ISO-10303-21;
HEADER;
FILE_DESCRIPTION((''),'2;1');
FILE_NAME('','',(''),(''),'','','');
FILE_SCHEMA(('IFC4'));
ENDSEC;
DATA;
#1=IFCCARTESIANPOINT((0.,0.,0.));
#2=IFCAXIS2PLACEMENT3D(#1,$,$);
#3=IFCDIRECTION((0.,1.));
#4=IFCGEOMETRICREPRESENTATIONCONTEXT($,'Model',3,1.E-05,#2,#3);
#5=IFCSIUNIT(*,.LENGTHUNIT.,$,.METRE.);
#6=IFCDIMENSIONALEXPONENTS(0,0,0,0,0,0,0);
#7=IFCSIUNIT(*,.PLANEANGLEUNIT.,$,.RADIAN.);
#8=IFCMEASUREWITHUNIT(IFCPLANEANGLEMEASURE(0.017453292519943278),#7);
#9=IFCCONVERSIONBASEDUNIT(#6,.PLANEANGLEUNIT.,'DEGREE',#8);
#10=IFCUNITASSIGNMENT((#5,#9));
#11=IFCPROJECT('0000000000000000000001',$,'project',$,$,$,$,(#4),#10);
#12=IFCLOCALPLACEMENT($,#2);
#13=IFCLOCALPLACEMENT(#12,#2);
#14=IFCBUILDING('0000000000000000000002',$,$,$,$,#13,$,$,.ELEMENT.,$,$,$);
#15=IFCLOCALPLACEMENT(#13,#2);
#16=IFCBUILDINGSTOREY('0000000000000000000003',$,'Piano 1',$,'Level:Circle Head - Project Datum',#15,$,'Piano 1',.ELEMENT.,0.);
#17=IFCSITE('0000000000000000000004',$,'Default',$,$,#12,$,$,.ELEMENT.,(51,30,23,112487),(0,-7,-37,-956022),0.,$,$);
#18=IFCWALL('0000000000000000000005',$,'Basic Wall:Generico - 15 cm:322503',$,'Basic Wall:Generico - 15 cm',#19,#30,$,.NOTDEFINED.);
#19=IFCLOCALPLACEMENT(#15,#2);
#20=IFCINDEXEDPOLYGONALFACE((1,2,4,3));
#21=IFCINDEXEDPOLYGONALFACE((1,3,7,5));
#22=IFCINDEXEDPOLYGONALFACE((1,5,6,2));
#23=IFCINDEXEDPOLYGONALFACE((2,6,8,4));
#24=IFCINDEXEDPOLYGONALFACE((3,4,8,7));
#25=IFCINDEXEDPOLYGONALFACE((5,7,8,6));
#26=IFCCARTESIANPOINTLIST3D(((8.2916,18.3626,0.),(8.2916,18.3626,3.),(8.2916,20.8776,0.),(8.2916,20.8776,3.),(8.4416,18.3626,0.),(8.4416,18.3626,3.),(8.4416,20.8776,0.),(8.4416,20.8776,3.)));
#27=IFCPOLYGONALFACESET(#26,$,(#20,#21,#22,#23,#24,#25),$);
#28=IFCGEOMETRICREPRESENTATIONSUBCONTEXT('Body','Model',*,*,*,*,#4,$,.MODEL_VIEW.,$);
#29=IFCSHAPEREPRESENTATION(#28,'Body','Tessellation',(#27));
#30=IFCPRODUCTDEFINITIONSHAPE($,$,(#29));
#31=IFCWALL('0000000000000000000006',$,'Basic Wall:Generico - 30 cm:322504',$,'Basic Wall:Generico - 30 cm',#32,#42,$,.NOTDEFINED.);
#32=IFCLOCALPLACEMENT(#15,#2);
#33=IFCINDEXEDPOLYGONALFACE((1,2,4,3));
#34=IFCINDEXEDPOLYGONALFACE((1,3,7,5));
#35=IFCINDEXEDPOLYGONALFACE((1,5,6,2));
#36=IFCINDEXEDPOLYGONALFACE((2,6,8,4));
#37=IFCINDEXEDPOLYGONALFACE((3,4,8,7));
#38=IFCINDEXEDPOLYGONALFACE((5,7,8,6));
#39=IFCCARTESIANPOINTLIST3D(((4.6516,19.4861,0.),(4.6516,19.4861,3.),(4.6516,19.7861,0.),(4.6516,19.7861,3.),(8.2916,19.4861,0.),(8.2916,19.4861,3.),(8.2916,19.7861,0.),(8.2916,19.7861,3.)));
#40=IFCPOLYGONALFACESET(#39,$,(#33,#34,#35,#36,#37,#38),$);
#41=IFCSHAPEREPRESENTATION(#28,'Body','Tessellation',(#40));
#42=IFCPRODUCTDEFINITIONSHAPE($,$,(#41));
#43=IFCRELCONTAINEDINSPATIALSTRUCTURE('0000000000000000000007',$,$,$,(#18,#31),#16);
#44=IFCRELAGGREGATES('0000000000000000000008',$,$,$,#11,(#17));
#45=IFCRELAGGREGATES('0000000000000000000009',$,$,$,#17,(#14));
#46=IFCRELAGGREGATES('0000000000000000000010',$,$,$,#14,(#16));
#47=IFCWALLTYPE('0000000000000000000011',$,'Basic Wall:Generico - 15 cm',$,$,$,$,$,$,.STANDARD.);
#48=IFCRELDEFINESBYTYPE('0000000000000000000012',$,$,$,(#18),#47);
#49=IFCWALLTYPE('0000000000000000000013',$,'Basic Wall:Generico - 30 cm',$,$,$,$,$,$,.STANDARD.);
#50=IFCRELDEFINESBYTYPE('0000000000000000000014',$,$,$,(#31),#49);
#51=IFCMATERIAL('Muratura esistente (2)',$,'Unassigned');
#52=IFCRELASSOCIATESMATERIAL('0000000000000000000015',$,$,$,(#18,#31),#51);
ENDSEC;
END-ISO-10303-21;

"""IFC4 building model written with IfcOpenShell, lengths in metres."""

from ifc_helpers import new_model, entity, si_unit, converted_unit, direction, frame, origin, place, context, subcontext, project, spatial, indexed_curve, outline, extrude, material, type_object, element, save


model = new_model("IFC4")

# Units and contexts
model_context = context("Model", 3, precision=1e-05, world=origin(), true_north=direction((0.0, 1.0)))
body_context = subcontext(model_context, "Body", "Model", "MODEL_VIEW")
ifc_project = project(units=[si_unit("LENGTHUNIT", "METRE"), converted_unit("PLANEANGLEUNIT", "DEGREE", entity("IfcPlaneAngleMeasure", 0.017453292519943278), si_unit("PLANEANGLEUNIT", "RADIAN"), dimensions=[0, 0, 0, 0, 0, 0, 0])], contexts=[model_context])

# Site, building, storey
site_placement = place(None, origin())
site = spatial("IfcSite", under=ifc_project, at=site_placement, Name="Default", CompositionType="ELEMENT", RefLatitude=(51, 30, 23, 112487), RefLongitude=(0, -7, -37, -956022), RefElevation=0.0)
building_placement = place(site_placement, origin())
building = spatial("IfcBuilding", under=site, at=building_placement, CompositionType="ELEMENT")
storey_placement = place(building_placement, origin())
storey = spatial("IfcBuildingStorey", under=building, at=storey_placement, Name="Piano 1", ObjectType="Level:Circle Head - Project Datum", LongName="Piano 1", CompositionType="ELEMENT", Elevation=0.0)

# Walls
ifc_material = material(Name="Muratura esistente (2)", Category="Unassigned")
wall_type_1 = type_object("IfcWallType", Name="Basic Wall:Generico - 15 cm", PredefinedType="STANDARD")
wall_1_placement = place(storey_placement, frame((8.3666, 20.8776, 0.0), z_axis=(0.0, 0.0, 1.0), x_axis=(0.0, -1.0, 0.0)))
element("IfcWall", 1, at=wall_1_placement, inside=storey, type_object=wall_type_1, material=ifc_material, Name="Basic Wall:Generico - 15 cm:322503", ObjectType="Basic Wall:Generico - 15 cm", PredefinedType="NOTDEFINED", context=body_context, shape_type="SweptSolid", body=[
    extrude(outline(indexed_curve([(2.515, 0.075), (0.0, 0.075), (0.0, -0.075), (2.515, -0.075), (2.515, 0.075)], self_intersect=False)), origin(), (0.0, 0.0, 1.0), 3.0),
])
wall_type_2 = type_object("IfcWallType", Name="Basic Wall:Generico - 30 cm", PredefinedType="STANDARD")
wall_2_placement = place(storey_placement, frame((4.6516, 19.6361, 0.0)))
element("IfcWall", 2, at=wall_2_placement, inside=storey, type_object=wall_type_2, material=ifc_material, Name="Basic Wall:Generico - 30 cm:322504", ObjectType="Basic Wall:Generico - 30 cm", PredefinedType="NOTDEFINED", context=body_context, shape_type="SweptSolid", body=[
    extrude(outline(indexed_curve([(3.64, 0.15), (0.0, 0.15), (0.0, -0.15), (3.64, -0.15), (3.64, 0.15)], self_intersect=False)), origin(), (0.0, 0.0, 1.0), 3.0),
])

save(model, "model.ifc")
